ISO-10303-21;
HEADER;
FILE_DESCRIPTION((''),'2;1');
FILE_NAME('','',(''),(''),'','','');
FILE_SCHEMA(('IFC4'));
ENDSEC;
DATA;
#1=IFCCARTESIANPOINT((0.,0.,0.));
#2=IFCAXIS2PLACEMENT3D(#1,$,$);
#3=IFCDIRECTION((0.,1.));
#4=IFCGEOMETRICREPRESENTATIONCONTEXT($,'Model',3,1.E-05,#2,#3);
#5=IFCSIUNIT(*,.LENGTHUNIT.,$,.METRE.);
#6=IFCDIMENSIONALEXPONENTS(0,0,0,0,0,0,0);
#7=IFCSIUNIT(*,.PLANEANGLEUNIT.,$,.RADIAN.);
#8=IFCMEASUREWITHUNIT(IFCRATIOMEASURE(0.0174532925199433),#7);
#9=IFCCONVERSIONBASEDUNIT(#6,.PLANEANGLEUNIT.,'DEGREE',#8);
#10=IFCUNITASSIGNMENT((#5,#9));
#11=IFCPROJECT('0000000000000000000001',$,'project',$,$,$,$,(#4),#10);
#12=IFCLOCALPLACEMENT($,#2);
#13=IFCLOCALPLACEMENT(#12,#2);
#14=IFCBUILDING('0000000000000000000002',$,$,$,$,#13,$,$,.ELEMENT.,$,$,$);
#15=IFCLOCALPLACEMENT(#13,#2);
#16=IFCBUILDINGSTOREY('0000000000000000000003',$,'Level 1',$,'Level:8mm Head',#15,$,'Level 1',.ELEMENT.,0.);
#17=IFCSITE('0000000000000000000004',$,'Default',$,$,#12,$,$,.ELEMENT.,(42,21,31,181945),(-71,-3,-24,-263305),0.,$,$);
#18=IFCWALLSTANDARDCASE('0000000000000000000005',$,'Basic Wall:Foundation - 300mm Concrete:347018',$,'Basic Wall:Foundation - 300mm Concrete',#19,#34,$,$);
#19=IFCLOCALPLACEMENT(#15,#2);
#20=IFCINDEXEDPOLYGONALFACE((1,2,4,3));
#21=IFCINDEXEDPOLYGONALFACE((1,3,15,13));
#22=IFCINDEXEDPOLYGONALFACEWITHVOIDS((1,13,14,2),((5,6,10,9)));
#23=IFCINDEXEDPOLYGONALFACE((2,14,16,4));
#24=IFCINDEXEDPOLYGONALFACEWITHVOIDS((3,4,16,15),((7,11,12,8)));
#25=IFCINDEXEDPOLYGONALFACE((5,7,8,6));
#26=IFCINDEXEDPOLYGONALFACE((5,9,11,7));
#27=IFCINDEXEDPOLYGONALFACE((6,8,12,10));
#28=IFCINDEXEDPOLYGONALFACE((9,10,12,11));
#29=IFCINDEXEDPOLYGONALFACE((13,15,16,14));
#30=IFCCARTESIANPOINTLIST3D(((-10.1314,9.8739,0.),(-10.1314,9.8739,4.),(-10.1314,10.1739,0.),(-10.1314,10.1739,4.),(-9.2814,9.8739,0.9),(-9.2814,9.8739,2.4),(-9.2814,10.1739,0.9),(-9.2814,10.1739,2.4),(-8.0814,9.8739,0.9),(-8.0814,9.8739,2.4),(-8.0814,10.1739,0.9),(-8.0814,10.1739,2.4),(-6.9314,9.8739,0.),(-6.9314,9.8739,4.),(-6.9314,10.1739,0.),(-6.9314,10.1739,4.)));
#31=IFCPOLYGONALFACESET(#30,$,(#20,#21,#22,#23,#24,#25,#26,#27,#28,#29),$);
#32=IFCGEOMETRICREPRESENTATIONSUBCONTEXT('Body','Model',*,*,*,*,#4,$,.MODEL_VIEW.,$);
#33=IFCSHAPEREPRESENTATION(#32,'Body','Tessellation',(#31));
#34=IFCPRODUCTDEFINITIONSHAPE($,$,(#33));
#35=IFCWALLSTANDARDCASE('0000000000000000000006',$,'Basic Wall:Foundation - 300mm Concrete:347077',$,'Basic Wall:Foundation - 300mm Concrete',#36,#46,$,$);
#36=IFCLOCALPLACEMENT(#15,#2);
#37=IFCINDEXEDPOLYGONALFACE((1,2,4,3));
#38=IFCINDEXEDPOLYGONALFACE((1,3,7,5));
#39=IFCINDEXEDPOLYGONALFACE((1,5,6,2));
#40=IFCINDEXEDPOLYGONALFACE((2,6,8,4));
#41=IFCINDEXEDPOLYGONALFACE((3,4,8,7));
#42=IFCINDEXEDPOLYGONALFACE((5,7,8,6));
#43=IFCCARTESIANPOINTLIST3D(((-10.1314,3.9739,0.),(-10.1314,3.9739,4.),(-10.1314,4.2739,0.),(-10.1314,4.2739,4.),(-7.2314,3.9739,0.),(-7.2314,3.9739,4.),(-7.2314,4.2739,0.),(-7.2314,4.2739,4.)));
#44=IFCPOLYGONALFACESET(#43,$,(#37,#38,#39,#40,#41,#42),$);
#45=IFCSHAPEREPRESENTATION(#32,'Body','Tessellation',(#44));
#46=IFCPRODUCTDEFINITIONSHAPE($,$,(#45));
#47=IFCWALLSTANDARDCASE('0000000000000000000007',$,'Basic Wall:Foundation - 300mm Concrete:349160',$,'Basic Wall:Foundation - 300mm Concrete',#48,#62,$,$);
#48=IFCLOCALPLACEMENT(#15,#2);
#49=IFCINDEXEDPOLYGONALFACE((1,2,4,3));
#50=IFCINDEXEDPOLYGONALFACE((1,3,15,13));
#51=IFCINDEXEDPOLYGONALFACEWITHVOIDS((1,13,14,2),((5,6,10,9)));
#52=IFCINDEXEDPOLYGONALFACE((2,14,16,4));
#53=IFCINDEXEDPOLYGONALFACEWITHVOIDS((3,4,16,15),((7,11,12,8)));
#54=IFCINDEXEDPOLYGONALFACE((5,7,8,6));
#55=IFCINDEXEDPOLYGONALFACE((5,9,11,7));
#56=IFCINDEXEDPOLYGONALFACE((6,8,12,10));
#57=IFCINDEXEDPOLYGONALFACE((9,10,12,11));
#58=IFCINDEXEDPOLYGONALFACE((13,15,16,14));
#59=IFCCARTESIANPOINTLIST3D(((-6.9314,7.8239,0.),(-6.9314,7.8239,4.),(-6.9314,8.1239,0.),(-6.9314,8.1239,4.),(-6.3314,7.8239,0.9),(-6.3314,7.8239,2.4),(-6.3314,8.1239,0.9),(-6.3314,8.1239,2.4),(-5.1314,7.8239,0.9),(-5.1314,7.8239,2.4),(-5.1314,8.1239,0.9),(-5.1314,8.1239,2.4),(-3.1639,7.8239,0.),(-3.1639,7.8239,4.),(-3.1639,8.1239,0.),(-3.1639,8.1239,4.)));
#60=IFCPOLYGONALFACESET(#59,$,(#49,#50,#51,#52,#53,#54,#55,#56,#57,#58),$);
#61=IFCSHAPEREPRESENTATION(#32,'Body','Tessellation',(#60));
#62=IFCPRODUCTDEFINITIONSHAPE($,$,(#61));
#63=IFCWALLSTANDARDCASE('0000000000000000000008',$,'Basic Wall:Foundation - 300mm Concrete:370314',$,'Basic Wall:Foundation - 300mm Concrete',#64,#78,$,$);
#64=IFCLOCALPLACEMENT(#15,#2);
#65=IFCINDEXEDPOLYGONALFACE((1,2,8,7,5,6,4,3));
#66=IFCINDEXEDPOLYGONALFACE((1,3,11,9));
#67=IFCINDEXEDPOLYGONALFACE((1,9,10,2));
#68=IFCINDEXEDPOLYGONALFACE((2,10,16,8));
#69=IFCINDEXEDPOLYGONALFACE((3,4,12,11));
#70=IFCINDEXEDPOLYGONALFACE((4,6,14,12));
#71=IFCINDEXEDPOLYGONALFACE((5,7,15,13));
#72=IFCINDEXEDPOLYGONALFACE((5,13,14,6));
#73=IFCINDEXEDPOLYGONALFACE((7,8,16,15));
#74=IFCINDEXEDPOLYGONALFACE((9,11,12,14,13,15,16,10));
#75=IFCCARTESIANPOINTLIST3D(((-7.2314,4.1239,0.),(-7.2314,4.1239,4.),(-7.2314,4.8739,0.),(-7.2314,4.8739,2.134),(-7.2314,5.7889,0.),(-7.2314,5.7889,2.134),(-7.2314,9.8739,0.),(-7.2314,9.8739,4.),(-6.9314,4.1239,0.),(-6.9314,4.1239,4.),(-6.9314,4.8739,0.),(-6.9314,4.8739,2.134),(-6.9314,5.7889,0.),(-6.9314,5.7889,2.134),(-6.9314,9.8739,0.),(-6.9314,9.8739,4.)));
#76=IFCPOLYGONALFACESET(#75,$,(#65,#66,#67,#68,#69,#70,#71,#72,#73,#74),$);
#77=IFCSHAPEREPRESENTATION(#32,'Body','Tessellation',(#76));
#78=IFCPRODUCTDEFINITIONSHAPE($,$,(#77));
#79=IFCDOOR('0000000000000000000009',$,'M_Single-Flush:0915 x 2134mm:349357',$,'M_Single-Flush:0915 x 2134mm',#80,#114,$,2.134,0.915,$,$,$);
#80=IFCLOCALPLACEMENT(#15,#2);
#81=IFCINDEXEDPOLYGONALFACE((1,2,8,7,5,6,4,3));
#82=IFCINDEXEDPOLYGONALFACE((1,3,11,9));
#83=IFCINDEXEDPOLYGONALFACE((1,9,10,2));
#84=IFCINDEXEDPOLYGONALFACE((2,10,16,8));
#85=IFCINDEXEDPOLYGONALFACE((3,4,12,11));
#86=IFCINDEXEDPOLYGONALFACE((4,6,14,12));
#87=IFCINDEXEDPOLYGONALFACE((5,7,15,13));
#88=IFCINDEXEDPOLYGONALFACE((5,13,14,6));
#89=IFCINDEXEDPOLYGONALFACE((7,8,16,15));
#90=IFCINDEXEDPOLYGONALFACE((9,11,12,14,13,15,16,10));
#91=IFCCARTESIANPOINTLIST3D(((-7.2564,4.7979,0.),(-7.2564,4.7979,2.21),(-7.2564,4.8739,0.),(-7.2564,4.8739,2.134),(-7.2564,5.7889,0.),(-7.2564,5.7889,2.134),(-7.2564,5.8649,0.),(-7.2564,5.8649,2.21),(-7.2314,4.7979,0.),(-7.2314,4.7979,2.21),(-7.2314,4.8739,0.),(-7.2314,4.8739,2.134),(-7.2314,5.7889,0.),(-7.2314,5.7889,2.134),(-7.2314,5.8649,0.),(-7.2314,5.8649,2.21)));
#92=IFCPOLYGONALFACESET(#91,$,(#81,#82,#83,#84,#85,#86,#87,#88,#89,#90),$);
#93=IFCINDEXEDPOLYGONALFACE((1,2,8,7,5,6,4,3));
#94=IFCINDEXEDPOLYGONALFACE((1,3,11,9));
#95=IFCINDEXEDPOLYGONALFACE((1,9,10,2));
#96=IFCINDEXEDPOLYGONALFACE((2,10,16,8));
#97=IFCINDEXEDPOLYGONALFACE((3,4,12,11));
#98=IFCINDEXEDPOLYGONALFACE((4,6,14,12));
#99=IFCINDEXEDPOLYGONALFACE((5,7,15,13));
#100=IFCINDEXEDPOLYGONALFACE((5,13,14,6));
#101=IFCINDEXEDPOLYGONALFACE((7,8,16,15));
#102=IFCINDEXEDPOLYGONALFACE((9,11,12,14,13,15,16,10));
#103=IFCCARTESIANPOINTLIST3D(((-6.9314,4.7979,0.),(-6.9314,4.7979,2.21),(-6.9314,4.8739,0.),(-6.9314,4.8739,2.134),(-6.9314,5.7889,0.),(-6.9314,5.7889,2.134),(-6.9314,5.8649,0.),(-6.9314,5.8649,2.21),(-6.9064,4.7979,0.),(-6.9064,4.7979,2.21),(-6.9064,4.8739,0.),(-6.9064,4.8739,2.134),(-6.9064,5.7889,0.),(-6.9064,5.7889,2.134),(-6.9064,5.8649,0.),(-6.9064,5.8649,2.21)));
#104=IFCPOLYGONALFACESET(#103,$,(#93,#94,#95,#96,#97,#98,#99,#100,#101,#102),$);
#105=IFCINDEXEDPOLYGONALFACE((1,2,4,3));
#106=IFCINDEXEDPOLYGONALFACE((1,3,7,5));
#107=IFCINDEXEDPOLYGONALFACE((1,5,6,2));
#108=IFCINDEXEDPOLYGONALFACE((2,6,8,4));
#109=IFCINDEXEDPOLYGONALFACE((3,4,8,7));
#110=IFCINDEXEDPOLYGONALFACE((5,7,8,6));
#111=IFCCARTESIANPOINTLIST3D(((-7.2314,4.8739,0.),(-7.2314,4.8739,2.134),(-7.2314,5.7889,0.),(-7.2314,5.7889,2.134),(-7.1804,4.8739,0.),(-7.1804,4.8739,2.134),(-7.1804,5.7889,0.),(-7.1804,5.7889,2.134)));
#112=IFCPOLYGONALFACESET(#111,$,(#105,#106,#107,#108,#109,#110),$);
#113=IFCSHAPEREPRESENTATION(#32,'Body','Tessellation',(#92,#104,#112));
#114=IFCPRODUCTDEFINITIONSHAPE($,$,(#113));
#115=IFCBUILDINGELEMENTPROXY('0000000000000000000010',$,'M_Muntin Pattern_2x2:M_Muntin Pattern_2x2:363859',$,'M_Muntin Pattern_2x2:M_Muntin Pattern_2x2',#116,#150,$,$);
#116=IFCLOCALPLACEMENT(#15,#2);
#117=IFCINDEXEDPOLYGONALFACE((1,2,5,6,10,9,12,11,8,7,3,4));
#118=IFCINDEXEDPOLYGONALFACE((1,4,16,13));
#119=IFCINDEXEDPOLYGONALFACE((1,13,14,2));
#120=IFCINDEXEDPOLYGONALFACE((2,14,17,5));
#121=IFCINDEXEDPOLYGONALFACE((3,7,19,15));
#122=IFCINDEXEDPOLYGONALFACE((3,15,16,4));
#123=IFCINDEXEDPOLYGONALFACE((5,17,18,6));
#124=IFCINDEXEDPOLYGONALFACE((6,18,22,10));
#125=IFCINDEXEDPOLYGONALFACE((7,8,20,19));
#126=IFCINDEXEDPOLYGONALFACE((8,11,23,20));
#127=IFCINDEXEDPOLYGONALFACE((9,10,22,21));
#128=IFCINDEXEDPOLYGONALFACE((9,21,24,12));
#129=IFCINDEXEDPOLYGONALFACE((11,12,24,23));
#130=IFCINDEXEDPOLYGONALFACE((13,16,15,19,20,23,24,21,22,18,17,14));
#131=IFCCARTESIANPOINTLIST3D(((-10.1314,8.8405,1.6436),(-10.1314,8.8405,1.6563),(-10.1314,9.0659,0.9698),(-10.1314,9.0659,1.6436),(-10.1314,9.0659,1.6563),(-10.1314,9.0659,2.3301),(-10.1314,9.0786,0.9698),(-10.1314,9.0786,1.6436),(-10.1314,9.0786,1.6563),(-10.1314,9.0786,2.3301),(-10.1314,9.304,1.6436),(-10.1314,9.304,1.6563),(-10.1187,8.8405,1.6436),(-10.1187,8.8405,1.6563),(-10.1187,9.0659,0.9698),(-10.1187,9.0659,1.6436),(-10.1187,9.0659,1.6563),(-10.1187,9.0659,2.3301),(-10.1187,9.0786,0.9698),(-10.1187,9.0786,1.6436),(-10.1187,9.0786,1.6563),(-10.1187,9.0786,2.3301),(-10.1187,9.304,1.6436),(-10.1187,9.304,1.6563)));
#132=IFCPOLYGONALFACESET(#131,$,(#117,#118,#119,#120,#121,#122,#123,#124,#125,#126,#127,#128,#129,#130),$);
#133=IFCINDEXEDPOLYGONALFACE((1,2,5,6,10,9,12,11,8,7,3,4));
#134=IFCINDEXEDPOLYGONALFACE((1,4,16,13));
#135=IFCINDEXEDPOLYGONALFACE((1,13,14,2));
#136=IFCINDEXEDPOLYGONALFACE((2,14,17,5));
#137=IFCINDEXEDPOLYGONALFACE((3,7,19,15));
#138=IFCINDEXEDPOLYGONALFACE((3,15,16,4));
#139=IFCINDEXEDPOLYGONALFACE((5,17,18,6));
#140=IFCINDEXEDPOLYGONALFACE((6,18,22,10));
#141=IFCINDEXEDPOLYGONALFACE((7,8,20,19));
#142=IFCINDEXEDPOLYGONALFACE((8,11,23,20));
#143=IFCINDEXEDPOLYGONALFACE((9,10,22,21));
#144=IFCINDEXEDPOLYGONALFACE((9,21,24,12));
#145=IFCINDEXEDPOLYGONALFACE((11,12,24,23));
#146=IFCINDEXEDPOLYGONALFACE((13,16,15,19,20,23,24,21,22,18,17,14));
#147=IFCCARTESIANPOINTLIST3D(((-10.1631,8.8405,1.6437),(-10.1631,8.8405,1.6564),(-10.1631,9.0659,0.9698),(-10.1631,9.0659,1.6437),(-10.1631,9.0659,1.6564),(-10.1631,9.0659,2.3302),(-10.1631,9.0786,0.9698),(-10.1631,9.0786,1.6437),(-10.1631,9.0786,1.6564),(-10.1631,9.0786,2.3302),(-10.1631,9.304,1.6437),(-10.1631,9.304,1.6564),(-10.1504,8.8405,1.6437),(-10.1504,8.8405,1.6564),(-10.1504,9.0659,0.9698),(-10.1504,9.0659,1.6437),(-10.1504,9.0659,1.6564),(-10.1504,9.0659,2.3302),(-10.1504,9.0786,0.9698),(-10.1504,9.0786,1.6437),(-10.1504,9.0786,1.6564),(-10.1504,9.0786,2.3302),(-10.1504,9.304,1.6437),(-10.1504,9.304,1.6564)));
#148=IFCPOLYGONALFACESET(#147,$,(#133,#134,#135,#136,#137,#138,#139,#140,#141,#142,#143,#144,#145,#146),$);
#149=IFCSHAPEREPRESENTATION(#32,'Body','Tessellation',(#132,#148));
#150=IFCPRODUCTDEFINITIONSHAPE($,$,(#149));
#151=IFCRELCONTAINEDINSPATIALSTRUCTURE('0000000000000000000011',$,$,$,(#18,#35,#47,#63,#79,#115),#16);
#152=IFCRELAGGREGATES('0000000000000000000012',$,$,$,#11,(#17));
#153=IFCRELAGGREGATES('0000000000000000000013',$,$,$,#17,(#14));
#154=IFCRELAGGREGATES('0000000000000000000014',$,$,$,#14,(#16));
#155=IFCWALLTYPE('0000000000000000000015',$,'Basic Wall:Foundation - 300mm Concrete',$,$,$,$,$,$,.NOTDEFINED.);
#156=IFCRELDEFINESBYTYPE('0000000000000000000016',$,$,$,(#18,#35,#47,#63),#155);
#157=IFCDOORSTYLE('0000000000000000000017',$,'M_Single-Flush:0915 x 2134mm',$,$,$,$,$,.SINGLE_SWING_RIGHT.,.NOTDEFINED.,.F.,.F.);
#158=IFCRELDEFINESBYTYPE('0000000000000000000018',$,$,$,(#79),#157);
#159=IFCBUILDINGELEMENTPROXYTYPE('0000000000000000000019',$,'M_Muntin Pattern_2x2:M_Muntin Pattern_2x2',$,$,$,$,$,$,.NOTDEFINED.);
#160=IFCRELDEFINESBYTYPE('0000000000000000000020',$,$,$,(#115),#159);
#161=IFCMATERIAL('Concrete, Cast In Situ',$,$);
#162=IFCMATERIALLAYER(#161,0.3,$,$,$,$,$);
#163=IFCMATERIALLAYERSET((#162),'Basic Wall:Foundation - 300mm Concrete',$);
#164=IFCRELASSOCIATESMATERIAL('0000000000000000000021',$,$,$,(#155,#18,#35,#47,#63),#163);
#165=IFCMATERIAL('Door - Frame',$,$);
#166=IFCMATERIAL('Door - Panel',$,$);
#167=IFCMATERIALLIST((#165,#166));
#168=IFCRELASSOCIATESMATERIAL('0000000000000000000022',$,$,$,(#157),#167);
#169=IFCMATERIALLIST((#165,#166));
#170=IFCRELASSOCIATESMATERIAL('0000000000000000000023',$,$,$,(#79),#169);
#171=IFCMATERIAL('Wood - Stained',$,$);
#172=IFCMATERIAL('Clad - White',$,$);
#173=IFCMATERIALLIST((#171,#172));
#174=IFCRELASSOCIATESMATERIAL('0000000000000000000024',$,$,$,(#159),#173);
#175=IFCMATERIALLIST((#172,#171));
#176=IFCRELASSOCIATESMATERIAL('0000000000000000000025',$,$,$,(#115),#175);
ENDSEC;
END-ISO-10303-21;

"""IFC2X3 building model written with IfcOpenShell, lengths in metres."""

from ifc_helpers import new_model, entity, si_unit, converted_unit, direction, frame, frame_2d, origin, place, context, subcontext, project, spatial, polyline, rectangle, outline, extrude, source, transform, mapped, material, material_list, layer, layer_set, layer_usage, type_object, type_shapes, element, fill, save


model = new_model("IFC2X3")

# Units and contexts
model_context = context("Model", 3, precision=1e-05, world=origin(), true_north=direction((0.0, 1.0)))
body_context = subcontext(model_context, "Body", "Model", "MODEL_VIEW")
ifc_project = project(units=[si_unit("LENGTHUNIT", "METRE"), converted_unit("PLANEANGLEUNIT", "DEGREE", entity("IfcRatioMeasure", 0.0174532925199433), si_unit("PLANEANGLEUNIT", "RADIAN"), dimensions=[0, 0, 0, 0, 0, 0, 0])], contexts=[model_context])

# Site, building, storey
site_placement = place(None, origin())
site = spatial("IfcSite", under=ifc_project, at=site_placement, Name="Default", CompositionType="ELEMENT", RefLatitude=(42, 21, 31, 181945), RefLongitude=(-71, -3, -24, -263305), RefElevation=0.0)
building_placement = place(site_placement, origin())
building = spatial("IfcBuilding", under=site, at=building_placement, CompositionType="ELEMENT")
storey_placement = place(building_placement, origin())
storey = spatial("IfcBuildingStorey", under=building, at=storey_placement, Name="Level 1", ObjectType="Level:8mm Head", LongName="Level 1", CompositionType="ELEMENT", Elevation=0.0)

# Wall, opening
ifc_material_1 = material(Name="Concrete, Cast In Situ")
ifc_layer = layer(ifc_material_1, 0.3)
ifc_layer_set = layer_set([ifc_layer], Name="Basic Wall:Foundation - 300mm Concrete")
ifc_layer_usage_1 = layer_usage(ifc_layer_set, "AXIS2", "NEGATIVE", 0.15)
wall_type = type_object("IfcWallType", Name="Basic Wall:Foundation - 300mm Concrete", PredefinedType="NOTDEFINED", material=ifc_layer_set)
wall_1_placement = place(storey_placement, frame((-10.1314, 10.0239, 0.0)))
wall_1 = element("IfcWallStandardCase", 1, at=wall_1_placement, inside=storey, type_object=wall_type, material=ifc_layer_usage_1, Name="Basic Wall:Foundation - 300mm Concrete:347018", ObjectType="Basic Wall:Foundation - 300mm Concrete", context=body_context, shape_type="SweptSolid", body=[
    extrude(rectangle(XDim=3.2, YDim=0.3, at=frame_2d((1.6, 0.0), x_axis=(-1.0, 0.0))), origin(), (0.0, 0.0, 1.0), 4.0),
])
opening_1_placement = place(wall_1_placement, frame((2.05, 0.15, 0.9)))
element("IfcOpeningElement", 2, at=opening_1_placement, cuts=wall_1, ObjectType="Opening", context=body_context, shape_type="SweptSolid", body=[
    extrude(rectangle(XDim=1.5, YDim=1.2, at=frame_2d((0.75, 0.6), x_axis=(-1.0, 0.0))), frame((0.0, 0.0, 0.0), z_axis=(0.0, -1.0, 0.0), x_axis=(0.0, 0.0, 1.0)), (0.0, 0.0, 1.0), 0.3),
])

# Wall
ifc_layer_usage_2 = layer_usage(ifc_layer_set, "AXIS2", "NEGATIVE", 0.15)
wall_2_placement = place(storey_placement, frame((-7.2314, 4.1239, 0.0), z_axis=(0.0, 0.0, 1.0), x_axis=(-1.0, 0.0, 0.0)))
element("IfcWallStandardCase", 3, at=wall_2_placement, inside=storey, type_object=wall_type, material=ifc_layer_usage_2, Name="Basic Wall:Foundation - 300mm Concrete:347077", ObjectType="Basic Wall:Foundation - 300mm Concrete", context=body_context, shape_type="SweptSolid", body=[
    extrude(rectangle(XDim=2.9, YDim=0.3, at=frame_2d((1.45, 0.0), x_axis=(-1.0, 0.0))), origin(), (0.0, 0.0, 1.0), 4.0),
])

# Wall, opening
ifc_layer_usage_3 = layer_usage(ifc_layer_set, "AXIS2", "NEGATIVE", 0.15)
wall_3_placement = place(storey_placement, frame((-6.9314, 7.9739, 0.0)))
wall_3 = element("IfcWallStandardCase", 4, at=wall_3_placement, inside=storey, type_object=wall_type, material=ifc_layer_usage_3, Name="Basic Wall:Foundation - 300mm Concrete:349160", ObjectType="Basic Wall:Foundation - 300mm Concrete", context=body_context, shape_type="SweptSolid", body=[
    extrude(rectangle(XDim=3.7675, YDim=0.3, at=frame_2d((1.8838, 0.0), x_axis=(-1.0, 0.0))), origin(), (0.0, 0.0, 1.0), 4.0),
])
opening_2_placement = place(wall_3_placement, frame((1.8, 0.15, 0.9)))
element("IfcOpeningElement", 5, at=opening_2_placement, cuts=wall_3, ObjectType="Opening", context=body_context, shape_type="SweptSolid", body=[
    extrude(rectangle(XDim=1.5, YDim=1.2, at=frame_2d((0.75, 0.6), x_axis=(-1.0, 0.0))), frame((0.0, 0.0, 0.0), z_axis=(0.0, -1.0, 0.0), x_axis=(0.0, 0.0, 1.0)), (0.0, 0.0, 1.0), 0.3),
])

# Wall, opening, door
ifc_layer_usage_4 = layer_usage(ifc_layer_set, "AXIS2", "NEGATIVE", 0.15)
wall_4_placement = place(storey_placement, frame((-7.0814, 4.1239, 0.0), z_axis=(0.0, 0.0, 1.0), x_axis=(0.0, 1.0, 0.0)))
wall_4 = element("IfcWallStandardCase", 6, at=wall_4_placement, inside=storey, type_object=wall_type, material=ifc_layer_usage_4, Name="Basic Wall:Foundation - 300mm Concrete:370314", ObjectType="Basic Wall:Foundation - 300mm Concrete", context=body_context, shape_type="SweptSolid", body=[
    extrude(rectangle(XDim=5.75, YDim=0.3, at=frame_2d((2.875, 0.0), x_axis=(-1.0, 0.0))), origin(), (0.0, 0.0, 1.0), 4.0),
])
opening_3_placement = place(wall_4_placement, frame((0.75, -0.15, 0.0)))
opening_3 = element("IfcOpeningElement", 7, at=opening_3_placement, cuts=wall_4, ObjectType="Opening", context=body_context, shape_type="SweptSolid", body=[
    extrude(rectangle(XDim=0.915, YDim=2.134, at=frame_2d((1.067, 0.4575), x_axis=(0.0, 1.0))), frame((0.0, 0.0, 0.0), z_axis=(0.0, 1.0, 0.0), x_axis=(0.0, 0.0, 1.0)), (0.0, 0.0, 1.0), 0.3),
])
ifc_material_2 = material(Name="Door - Frame")
ifc_material_3 = material(Name="Door - Panel")
ifc_material_list_1 = material_list([ifc_material_2, ifc_material_3])
ifc_material_list_2 = material_list([ifc_material_2, ifc_material_3])
door_style = type_object("IfcDoorStyle", Name="M_Single-Flush:0915 x 2134mm", ConstructionType="NOTDEFINED", OperationType="SINGLE_SWING_RIGHT", ParameterTakesPrecedence=False, Sizeable=False, material=ifc_material_list_2)
shared_shape_1 = source(origin(), body_context, "Body", "SweptSolid", [
    extrude(outline(polyline([(-0.5335, -1.124), (0.5335, -1.124), (0.5335, 1.086), (0.4575, 1.086), (0.4575, -1.048), (-0.4575, -1.048), (-0.4575, 1.086), (-0.5335, 1.086), (-0.5335, -1.124)])), frame((0.4575, 0.3, 1.086), z_axis=(0.0, 1.0, 0.0), x_axis=(1.0, 0.0, 0.0)), (0.0, 0.0, 1.0), 0.025),
    extrude(outline(polyline([(-1.124, -0.5335), (1.086, -0.5335), (1.086, -0.4575), (-1.048, -0.4575), (-1.048, 0.4575), (1.086, 0.4575), (1.086, 0.5335), (-1.124, 0.5335), (-1.124, -0.5335)])), frame((0.4575, -0.025, 1.086), z_axis=(0.0, 1.0, 0.0), x_axis=(0.0, 0.0, -1.0)), (0.0, 0.0, 1.0), 0.025),
    extrude(rectangle(XDim=0.051, YDim=0.915, at=frame_2d((0.0, 0.0), x_axis=(1.0, 0.0))), frame((0.4575, 0.2745, 0.0), z_axis=(0.0, 0.0, 1.0), x_axis=(0.0, 1.0, 0.0)), (0.0, 0.0, 1.0), 2.134),
])
type_shapes(door_style, [shared_shape_1])
door_placement = place(opening_3_placement, origin())
door = element("IfcDoor", 8, at=door_placement, inside=storey, type_object=door_style, material=ifc_material_list_1, Name="M_Single-Flush:0915 x 2134mm:349357", ObjectType="M_Single-Flush:0915 x 2134mm", OverallHeight=2.134, OverallWidth=0.915, context=body_context, shape_type="MappedRepresentation", body=[
    mapped(shared_shape_1, transform((0.0, 0.0, 0.0), scale=1.0)),
])
fill(opening_3, door)

# Building element proxy
ifc_material_4 = material(Name="Clad - White")
ifc_material_5 = material(Name="Wood - Stained")
ifc_material_list_3 = material_list([ifc_material_4, ifc_material_5])
ifc_material_list_4 = material_list([ifc_material_5, ifc_material_4])
building_element_proxy_type_1 = type_object("IfcBuildingElementProxyType", Name="M_Muntin Pattern_2x2:M_Muntin Pattern_2x2", PredefinedType="NOTDEFINED", material=ifc_material_list_4)
shared_shape_2 = source(origin(), body_context, "Body", "SweptSolid", [
    extrude(outline(polyline([(0.0064, -0.0064), (0.6801, -0.0064), (0.6801, 0.0063), (0.0064, 0.0063), (0.0064, 0.2317), (-0.0063, 0.2317), (-0.0063, 0.0063), (-0.6802, 0.0063), (-0.6802, -0.0064), (-0.0063, -0.0064), (-0.0063, -0.2317), (0.0064, -0.2317), (0.0064, -0.0064)])), frame((0.0, 0.0095, 0.6801), z_axis=(0.0, 1.0, 0.0), x_axis=(0.0, 0.0, 1.0)), (0.0, 0.0, 1.0), 0.0127),
    extrude(outline(polyline([(0.0064, -0.0064), (0.6802, -0.0064), (0.6802, 0.0063), (0.0064, 0.0063), (0.0064, 0.2317), (-0.0063, 0.2317), (-0.0063, 0.0063), (-0.6802, 0.0063), (-0.6802, -0.0064), (-0.0063, -0.0064), (-0.0063, -0.2317), (0.0064, -0.2317), (0.0064, -0.0064)])), frame((0.0, -0.0222, 0.6802), z_axis=(0.0, 1.0, 0.0), x_axis=(0.0, 0.0, 1.0)), (0.0, 0.0, 1.0), 0.0127),
])
type_shapes(building_element_proxy_type_1, [shared_shape_2])
proxy_1_placement = place(storey_placement, frame((-10.1409, 9.0723, 0.9698), z_axis=(0.0, 0.0, 1.0), x_axis=(0.0, -1.0, 0.0)))
element("IfcBuildingElementProxy", 9, at=proxy_1_placement, inside=storey, type_object=building_element_proxy_type_1, material=ifc_material_list_3, Name="M_Muntin Pattern_2x2:M_Muntin Pattern_2x2:363859", ObjectType="M_Muntin Pattern_2x2:M_Muntin Pattern_2x2", context=body_context, shape_type="MappedRepresentation", body=[
    mapped(shared_shape_2, transform((0.0, 0.0, 0.0), scale=1.0)),
])

save(model, "model.ifc")
